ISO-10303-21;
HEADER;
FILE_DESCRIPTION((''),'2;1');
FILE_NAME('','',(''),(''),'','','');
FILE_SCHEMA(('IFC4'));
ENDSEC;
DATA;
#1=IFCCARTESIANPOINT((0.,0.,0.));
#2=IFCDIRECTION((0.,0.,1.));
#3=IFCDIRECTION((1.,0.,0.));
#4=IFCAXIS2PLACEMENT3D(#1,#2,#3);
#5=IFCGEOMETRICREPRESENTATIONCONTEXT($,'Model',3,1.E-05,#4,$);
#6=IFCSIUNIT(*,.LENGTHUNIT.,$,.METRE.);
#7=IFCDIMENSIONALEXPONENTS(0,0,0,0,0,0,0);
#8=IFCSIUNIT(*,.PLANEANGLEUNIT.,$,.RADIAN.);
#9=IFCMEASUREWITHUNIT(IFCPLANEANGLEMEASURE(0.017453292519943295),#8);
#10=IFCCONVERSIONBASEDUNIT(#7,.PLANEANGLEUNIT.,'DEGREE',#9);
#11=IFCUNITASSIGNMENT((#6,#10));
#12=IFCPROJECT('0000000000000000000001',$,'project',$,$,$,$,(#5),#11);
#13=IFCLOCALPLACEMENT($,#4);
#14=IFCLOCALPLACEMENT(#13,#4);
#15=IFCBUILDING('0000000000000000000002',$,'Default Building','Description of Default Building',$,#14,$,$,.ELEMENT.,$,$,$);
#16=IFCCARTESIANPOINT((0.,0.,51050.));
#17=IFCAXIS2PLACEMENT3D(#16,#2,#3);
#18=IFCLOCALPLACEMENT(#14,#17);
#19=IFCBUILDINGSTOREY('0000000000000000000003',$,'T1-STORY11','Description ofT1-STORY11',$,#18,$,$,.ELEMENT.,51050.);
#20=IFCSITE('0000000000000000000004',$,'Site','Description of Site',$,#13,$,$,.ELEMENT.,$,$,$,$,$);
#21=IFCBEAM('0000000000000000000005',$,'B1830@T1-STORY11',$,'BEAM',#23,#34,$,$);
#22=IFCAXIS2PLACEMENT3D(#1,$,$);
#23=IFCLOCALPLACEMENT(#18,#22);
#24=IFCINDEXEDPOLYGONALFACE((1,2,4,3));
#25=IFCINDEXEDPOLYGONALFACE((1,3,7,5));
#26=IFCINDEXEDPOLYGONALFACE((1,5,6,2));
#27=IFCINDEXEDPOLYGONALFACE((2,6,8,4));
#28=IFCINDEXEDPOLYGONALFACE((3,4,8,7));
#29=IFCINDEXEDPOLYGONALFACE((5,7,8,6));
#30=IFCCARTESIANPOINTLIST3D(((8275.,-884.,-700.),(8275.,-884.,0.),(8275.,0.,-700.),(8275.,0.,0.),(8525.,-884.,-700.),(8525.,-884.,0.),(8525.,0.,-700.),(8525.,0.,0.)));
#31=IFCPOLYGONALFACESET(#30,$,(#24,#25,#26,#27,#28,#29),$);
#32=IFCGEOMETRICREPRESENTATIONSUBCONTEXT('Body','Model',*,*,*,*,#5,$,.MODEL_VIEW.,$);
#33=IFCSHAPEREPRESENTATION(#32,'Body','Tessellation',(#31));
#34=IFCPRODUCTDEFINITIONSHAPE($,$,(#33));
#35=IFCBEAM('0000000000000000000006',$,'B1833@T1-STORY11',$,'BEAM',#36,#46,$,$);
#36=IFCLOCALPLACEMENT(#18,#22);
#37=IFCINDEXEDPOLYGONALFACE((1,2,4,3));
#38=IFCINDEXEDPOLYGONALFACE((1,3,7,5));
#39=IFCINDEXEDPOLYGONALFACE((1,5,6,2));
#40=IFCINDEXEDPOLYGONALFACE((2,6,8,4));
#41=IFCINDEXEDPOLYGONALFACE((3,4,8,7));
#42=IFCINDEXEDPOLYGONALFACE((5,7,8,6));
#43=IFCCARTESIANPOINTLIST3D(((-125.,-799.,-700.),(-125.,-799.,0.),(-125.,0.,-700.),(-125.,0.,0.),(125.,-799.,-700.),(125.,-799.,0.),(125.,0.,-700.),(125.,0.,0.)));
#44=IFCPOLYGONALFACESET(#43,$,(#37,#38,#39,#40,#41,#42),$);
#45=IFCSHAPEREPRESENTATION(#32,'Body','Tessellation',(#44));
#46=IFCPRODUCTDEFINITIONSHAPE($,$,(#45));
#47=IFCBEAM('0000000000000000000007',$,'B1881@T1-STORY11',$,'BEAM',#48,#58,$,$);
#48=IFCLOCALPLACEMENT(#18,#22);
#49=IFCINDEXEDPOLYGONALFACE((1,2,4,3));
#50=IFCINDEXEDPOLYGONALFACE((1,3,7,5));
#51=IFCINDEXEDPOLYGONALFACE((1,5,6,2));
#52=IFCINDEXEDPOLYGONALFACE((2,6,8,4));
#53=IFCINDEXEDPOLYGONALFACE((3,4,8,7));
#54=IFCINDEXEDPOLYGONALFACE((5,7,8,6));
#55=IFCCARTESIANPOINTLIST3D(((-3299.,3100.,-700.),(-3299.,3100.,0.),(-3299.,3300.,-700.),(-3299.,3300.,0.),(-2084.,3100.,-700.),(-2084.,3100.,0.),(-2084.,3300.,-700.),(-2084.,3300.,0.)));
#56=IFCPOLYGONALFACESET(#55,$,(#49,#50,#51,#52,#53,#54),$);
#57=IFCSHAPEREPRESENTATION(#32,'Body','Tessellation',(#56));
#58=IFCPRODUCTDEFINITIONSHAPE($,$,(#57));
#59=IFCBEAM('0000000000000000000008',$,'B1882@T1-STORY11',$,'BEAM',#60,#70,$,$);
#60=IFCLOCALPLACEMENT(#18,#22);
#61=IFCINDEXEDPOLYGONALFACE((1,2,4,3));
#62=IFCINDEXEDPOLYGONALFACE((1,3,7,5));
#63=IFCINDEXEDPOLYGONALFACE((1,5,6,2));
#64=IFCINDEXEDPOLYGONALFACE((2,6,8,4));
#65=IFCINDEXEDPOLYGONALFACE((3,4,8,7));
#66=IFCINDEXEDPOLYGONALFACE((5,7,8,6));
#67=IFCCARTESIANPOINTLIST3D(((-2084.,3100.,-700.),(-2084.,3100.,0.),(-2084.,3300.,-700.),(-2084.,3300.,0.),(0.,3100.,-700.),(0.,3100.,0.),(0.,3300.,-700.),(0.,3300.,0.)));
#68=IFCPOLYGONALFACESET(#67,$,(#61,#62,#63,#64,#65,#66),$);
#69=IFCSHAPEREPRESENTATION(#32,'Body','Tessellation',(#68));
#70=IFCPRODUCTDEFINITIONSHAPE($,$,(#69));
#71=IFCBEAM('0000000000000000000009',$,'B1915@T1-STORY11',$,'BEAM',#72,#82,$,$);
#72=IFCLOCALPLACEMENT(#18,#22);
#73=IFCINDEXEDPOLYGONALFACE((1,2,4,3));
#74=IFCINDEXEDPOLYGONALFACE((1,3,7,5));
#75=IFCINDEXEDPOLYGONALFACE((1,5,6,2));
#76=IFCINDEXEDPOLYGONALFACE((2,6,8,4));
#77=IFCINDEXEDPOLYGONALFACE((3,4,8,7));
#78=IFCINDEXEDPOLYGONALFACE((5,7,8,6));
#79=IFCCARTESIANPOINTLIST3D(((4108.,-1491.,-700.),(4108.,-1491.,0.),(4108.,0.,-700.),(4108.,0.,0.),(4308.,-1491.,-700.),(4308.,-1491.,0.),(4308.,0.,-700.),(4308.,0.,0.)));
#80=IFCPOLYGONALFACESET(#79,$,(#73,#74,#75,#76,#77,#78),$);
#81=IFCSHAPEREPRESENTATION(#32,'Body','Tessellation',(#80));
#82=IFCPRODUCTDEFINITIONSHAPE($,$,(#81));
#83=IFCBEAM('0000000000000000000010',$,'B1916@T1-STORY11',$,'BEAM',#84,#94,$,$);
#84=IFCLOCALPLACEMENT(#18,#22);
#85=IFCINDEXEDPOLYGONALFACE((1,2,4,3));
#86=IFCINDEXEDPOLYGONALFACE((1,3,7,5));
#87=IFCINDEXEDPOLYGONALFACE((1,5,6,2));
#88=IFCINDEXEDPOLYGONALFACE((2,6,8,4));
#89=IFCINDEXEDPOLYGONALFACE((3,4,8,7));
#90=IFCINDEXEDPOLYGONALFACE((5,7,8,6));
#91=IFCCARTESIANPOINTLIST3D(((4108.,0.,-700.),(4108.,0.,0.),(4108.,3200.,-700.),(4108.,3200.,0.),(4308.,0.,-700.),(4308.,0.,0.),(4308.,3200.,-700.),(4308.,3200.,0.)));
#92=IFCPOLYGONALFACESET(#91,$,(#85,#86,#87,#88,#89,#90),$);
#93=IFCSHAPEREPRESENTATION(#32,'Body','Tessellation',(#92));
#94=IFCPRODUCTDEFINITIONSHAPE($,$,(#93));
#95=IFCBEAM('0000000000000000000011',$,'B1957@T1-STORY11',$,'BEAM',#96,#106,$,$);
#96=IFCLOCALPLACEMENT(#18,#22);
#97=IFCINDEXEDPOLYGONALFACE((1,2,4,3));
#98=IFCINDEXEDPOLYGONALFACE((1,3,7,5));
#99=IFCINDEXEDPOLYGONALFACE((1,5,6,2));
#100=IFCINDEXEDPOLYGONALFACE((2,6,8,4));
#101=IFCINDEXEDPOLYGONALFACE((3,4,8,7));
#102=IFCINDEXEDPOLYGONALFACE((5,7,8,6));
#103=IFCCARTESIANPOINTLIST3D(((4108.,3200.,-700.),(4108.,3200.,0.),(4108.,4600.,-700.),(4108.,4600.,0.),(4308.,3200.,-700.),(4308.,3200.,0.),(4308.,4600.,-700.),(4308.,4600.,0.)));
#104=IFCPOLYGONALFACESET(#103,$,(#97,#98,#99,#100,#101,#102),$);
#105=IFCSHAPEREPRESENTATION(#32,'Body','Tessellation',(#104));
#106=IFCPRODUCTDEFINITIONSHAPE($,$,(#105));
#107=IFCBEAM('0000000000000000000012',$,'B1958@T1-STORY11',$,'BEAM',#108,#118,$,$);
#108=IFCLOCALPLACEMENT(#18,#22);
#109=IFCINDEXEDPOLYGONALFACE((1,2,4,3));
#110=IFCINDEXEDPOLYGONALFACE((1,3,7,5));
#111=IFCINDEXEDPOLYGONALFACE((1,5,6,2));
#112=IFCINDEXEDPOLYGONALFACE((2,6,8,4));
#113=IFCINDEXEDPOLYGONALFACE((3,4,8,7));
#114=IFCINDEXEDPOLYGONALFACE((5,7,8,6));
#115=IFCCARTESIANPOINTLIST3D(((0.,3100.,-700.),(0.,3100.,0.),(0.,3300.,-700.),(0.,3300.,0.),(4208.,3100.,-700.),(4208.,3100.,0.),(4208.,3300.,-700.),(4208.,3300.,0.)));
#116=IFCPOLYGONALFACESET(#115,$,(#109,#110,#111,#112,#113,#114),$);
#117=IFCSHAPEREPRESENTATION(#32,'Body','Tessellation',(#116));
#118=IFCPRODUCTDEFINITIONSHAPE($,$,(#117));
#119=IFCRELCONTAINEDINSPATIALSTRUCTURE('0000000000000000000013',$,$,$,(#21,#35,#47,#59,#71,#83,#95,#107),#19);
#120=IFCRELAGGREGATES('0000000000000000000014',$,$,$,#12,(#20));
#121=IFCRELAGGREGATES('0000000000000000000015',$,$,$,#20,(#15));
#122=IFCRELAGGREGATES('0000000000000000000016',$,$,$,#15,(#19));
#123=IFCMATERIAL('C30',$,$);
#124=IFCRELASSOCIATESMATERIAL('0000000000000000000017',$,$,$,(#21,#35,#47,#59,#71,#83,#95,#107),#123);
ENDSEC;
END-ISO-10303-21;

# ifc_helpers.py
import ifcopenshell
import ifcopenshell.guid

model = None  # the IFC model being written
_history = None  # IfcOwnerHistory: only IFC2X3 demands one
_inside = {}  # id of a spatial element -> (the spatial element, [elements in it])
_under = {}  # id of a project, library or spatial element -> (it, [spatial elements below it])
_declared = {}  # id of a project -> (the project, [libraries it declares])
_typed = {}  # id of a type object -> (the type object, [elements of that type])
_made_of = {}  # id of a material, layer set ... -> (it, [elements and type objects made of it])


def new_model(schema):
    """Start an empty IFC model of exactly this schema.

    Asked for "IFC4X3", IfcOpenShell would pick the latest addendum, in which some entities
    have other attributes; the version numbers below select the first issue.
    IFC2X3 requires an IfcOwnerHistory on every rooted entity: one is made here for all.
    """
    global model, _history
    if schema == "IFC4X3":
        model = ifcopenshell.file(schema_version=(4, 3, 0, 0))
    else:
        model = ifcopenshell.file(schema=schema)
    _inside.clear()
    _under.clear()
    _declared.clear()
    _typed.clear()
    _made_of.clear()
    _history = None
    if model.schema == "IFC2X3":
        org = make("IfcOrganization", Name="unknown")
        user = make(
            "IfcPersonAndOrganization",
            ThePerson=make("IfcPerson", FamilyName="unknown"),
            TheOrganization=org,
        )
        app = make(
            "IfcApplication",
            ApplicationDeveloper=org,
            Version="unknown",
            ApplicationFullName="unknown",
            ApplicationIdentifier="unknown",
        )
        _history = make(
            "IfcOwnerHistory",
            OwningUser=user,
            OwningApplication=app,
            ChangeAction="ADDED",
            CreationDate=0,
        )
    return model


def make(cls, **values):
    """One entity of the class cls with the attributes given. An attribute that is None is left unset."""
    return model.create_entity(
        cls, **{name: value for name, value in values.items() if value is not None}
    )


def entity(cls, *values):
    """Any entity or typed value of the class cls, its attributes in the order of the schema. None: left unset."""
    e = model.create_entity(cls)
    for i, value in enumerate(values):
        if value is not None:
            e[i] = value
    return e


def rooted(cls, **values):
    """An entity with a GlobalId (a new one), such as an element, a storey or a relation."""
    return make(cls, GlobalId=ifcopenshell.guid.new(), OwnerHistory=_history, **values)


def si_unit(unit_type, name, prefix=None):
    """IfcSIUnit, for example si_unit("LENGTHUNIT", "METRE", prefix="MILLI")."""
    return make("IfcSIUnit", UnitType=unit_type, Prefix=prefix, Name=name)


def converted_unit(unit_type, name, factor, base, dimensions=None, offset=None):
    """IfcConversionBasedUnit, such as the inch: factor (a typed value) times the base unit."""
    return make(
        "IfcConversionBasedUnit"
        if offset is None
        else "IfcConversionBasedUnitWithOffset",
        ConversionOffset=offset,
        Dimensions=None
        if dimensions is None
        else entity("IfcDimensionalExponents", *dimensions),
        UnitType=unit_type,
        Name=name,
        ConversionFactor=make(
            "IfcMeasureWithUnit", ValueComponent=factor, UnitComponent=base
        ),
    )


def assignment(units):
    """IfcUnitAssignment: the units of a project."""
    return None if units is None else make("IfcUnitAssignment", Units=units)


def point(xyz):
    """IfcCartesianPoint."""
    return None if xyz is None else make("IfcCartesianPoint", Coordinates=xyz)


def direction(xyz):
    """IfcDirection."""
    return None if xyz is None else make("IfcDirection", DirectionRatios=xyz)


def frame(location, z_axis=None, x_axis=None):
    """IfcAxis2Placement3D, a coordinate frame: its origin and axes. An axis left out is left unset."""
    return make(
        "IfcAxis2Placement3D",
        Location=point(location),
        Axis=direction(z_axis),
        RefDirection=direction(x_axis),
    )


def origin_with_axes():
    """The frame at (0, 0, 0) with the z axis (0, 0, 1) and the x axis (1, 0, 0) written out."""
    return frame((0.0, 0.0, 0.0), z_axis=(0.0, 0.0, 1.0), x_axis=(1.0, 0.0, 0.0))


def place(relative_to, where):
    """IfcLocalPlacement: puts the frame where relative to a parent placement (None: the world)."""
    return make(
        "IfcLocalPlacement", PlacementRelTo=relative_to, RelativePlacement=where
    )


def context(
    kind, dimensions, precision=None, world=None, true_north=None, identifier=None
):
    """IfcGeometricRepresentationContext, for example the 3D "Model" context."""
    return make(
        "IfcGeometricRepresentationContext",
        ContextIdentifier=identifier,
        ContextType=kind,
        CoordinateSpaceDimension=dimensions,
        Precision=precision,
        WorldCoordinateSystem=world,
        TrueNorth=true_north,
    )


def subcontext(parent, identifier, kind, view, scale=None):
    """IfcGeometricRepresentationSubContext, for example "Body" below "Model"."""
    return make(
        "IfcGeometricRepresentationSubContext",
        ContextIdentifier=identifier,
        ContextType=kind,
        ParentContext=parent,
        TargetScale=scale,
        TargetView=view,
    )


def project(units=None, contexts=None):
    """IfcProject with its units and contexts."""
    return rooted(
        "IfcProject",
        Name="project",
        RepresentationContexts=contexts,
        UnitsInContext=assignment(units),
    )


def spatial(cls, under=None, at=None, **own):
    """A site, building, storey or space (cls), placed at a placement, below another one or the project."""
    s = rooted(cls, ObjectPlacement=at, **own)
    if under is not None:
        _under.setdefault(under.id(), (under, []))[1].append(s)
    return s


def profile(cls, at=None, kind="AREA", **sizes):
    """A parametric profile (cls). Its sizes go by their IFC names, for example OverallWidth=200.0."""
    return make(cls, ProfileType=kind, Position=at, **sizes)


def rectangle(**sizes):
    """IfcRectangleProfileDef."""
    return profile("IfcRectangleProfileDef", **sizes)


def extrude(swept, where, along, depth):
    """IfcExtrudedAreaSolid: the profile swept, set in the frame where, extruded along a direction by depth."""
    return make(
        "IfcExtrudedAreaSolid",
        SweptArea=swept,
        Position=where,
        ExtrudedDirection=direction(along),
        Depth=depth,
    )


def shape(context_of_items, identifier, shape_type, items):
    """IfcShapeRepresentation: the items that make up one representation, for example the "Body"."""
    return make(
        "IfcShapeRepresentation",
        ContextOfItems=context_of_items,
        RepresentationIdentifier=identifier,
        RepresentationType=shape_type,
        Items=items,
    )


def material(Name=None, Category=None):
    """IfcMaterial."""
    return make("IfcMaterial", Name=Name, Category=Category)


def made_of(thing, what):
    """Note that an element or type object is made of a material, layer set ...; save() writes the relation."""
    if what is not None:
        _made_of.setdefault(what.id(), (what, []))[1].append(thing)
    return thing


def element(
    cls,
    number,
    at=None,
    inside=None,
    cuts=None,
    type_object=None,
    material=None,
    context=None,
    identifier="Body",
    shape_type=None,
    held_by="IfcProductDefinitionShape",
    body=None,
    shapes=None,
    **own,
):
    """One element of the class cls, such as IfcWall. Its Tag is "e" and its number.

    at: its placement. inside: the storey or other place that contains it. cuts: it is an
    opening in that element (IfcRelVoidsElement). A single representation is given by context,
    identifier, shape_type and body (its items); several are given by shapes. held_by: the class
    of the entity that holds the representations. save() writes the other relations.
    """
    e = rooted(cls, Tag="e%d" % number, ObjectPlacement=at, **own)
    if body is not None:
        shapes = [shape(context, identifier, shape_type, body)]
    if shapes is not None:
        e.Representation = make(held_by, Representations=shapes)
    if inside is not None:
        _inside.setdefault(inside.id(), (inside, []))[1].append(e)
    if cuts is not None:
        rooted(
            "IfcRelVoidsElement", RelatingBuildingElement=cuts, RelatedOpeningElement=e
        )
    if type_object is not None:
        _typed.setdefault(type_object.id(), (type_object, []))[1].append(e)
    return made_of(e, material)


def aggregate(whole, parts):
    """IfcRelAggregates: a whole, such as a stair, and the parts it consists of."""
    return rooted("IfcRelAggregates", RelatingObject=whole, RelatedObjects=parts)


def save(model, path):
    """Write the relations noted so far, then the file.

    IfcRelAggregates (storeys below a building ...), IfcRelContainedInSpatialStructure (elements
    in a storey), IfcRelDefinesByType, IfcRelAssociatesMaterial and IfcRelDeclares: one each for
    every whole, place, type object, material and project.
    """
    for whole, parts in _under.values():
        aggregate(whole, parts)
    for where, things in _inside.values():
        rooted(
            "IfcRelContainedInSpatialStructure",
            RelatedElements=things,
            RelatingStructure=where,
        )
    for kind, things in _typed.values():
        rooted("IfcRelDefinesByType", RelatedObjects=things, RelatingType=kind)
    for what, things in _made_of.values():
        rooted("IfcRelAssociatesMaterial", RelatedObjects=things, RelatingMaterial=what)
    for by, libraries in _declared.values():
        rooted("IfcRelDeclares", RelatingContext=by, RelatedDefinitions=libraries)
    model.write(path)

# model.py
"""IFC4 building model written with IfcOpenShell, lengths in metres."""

from ifc_helpers import new_model, entity, si_unit, converted_unit, frame, origin_with_axes, place, context, subcontext, project, spatial, rectangle, extrude, material, element, save


model = new_model("IFC4")

# Units and contexts
model_context = context("Model", 3, precision=1e-05, world=origin_with_axes())
body_context = subcontext(model_context, "Body", "Model", "MODEL_VIEW")
ifc_project = project(units=[si_unit("LENGTHUNIT", "METRE"), converted_unit("PLANEANGLEUNIT", "DEGREE", entity("IfcPlaneAngleMeasure", 0.017453292519943295), si_unit("PLANEANGLEUNIT", "RADIAN"), dimensions=[0, 0, 0, 0, 0, 0, 0])], contexts=[model_context])

# Site, building, storey
site_placement = place(None, origin_with_axes())
site = spatial("IfcSite", under=ifc_project, at=site_placement, Name="Site", Description="Description of Site", CompositionType="ELEMENT")
building_placement = place(site_placement, origin_with_axes())
building = spatial("IfcBuilding", under=site, at=building_placement, Name="Default Building", Description="Description of Default Building", CompositionType="ELEMENT")
storey_placement = place(building_placement, frame((0.0, 0.0, 51050.0), z_axis=(0.0, 0.0, 1.0), x_axis=(1.0, 0.0, 0.0)))
storey = spatial("IfcBuildingStorey", under=building, at=storey_placement, Name="T1-STORY11", Description="Description ofT1-STORY11", CompositionType="ELEMENT", Elevation=51050.0)

# Beams
ifc_material_1 = material(Name="C30")
beam_1_placement = place(storey_placement, frame((8400.0, -884.0, -350.0), z_axis=(0.0, 1.0, 0.0), x_axis=(-1.0, 0.0, 0.0)))
element("IfcBeam", 1, at=beam_1_placement, inside=storey, material=ifc_material_1, Name="B1830@T1-STORY11", ObjectType="BEAM", context=body_context, shape_type="SweptSolid", body=[
    extrude(rectangle(XDim=250.0, YDim=700.0), origin_with_axes(), (0.0, 0.0, 1.0), 884.0),
])
beam_2_placement = place(storey_placement, frame((0.0, -799.0, -350.0), z_axis=(0.0, 1.0, 0.0), x_axis=(-1.0, 0.0, 0.0)))
element("IfcBeam", 2, at=beam_2_placement, inside=storey, material=ifc_material_1, Name="B1833@T1-STORY11", ObjectType="BEAM", context=body_context, shape_type="SweptSolid", body=[
    extrude(rectangle(XDim=250.0, YDim=700.0), origin_with_axes(), (0.0, 0.0, 1.0), 799.0),
])
beam_3_placement = place(storey_placement, frame((-3299.0, 3200.0, -350.0), z_axis=(1.0, 0.0, 0.0), x_axis=(0.0, 1.0, 0.0)))
element("IfcBeam", 3, at=beam_3_placement, inside=storey, material=ifc_material_1, Name="B1881@T1-STORY11", ObjectType="BEAM", context=body_context, shape_type="SweptSolid", body=[
    extrude(rectangle(XDim=200.0, YDim=700.0), origin_with_axes(), (0.0, 0.0, 1.0), 1215.0),
])
beam_4_placement = place(storey_placement, frame((-2084.0, 3200.0, -350.0), z_axis=(1.0, 0.0, 0.0), x_axis=(0.0, 1.0, 0.0)))
element("IfcBeam", 4, at=beam_4_placement, inside=storey, material=ifc_material_1, Name="B1882@T1-STORY11", ObjectType="BEAM", context=body_context, shape_type="SweptSolid", body=[
    extrude(rectangle(XDim=200.0, YDim=700.0), origin_with_axes(), (0.0, 0.0, 1.0), 2084.0),
])
beam_5_placement = place(storey_placement, frame((4208.0, -1491.0, -350.0), z_axis=(0.0, 1.0, 0.0), x_axis=(-1.0, 0.0, 0.0)))
element("IfcBeam", 5, at=beam_5_placement, inside=storey, material=ifc_material_1, Name="B1915@T1-STORY11", ObjectType="BEAM", context=body_context, shape_type="SweptSolid", body=[
    extrude(rectangle(XDim=200.0, YDim=700.0), origin_with_axes(), (0.0, 0.0, 1.0), 1491.0),
])
beam_6_placement = place(storey_placement, frame((4208.0, 0.0, -350.0), z_axis=(0.0, 1.0, 0.0), x_axis=(-1.0, 0.0, 0.0)))
element("IfcBeam", 6, at=beam_6_placement, inside=storey, material=ifc_material_1, Name="B1916@T1-STORY11", ObjectType="BEAM", context=body_context, shape_type="SweptSolid", body=[
    extrude(rectangle(XDim=200.0, YDim=700.0), origin_with_axes(), (0.0, 0.0, 1.0), 3200.0),
])
beam_7_placement = place(storey_placement, frame((4208.0, 3200.0, -350.0), z_axis=(0.0, 1.0, 0.0), x_axis=(-1.0, 0.0, 0.0)))
element("IfcBeam", 7, at=beam_7_placement, inside=storey, material=ifc_material_1, Name="B1957@T1-STORY11", ObjectType="BEAM", context=body_context, shape_type="SweptSolid", body=[
    extrude(rectangle(XDim=200.0, YDim=700.0), origin_with_axes(), (0.0, 0.0, 1.0), 1400.0),
])
beam_8_placement = place(storey_placement, frame((0.0, 3200.0, -350.0), z_axis=(1.0, 0.0, 0.0), x_axis=(0.0, 1.0, 0.0)))
element("IfcBeam", 8, at=beam_8_placement, inside=storey, material=ifc_material_1, Name="B1958@T1-STORY11", ObjectType="BEAM", context=body_context, shape_type="SweptSolid", body=[
    extrude(rectangle(XDim=200.0, YDim=700.0), origin_with_axes(), (0.0, 0.0, 1.0), 4208.0),
])

save(model, "model.ifc")
